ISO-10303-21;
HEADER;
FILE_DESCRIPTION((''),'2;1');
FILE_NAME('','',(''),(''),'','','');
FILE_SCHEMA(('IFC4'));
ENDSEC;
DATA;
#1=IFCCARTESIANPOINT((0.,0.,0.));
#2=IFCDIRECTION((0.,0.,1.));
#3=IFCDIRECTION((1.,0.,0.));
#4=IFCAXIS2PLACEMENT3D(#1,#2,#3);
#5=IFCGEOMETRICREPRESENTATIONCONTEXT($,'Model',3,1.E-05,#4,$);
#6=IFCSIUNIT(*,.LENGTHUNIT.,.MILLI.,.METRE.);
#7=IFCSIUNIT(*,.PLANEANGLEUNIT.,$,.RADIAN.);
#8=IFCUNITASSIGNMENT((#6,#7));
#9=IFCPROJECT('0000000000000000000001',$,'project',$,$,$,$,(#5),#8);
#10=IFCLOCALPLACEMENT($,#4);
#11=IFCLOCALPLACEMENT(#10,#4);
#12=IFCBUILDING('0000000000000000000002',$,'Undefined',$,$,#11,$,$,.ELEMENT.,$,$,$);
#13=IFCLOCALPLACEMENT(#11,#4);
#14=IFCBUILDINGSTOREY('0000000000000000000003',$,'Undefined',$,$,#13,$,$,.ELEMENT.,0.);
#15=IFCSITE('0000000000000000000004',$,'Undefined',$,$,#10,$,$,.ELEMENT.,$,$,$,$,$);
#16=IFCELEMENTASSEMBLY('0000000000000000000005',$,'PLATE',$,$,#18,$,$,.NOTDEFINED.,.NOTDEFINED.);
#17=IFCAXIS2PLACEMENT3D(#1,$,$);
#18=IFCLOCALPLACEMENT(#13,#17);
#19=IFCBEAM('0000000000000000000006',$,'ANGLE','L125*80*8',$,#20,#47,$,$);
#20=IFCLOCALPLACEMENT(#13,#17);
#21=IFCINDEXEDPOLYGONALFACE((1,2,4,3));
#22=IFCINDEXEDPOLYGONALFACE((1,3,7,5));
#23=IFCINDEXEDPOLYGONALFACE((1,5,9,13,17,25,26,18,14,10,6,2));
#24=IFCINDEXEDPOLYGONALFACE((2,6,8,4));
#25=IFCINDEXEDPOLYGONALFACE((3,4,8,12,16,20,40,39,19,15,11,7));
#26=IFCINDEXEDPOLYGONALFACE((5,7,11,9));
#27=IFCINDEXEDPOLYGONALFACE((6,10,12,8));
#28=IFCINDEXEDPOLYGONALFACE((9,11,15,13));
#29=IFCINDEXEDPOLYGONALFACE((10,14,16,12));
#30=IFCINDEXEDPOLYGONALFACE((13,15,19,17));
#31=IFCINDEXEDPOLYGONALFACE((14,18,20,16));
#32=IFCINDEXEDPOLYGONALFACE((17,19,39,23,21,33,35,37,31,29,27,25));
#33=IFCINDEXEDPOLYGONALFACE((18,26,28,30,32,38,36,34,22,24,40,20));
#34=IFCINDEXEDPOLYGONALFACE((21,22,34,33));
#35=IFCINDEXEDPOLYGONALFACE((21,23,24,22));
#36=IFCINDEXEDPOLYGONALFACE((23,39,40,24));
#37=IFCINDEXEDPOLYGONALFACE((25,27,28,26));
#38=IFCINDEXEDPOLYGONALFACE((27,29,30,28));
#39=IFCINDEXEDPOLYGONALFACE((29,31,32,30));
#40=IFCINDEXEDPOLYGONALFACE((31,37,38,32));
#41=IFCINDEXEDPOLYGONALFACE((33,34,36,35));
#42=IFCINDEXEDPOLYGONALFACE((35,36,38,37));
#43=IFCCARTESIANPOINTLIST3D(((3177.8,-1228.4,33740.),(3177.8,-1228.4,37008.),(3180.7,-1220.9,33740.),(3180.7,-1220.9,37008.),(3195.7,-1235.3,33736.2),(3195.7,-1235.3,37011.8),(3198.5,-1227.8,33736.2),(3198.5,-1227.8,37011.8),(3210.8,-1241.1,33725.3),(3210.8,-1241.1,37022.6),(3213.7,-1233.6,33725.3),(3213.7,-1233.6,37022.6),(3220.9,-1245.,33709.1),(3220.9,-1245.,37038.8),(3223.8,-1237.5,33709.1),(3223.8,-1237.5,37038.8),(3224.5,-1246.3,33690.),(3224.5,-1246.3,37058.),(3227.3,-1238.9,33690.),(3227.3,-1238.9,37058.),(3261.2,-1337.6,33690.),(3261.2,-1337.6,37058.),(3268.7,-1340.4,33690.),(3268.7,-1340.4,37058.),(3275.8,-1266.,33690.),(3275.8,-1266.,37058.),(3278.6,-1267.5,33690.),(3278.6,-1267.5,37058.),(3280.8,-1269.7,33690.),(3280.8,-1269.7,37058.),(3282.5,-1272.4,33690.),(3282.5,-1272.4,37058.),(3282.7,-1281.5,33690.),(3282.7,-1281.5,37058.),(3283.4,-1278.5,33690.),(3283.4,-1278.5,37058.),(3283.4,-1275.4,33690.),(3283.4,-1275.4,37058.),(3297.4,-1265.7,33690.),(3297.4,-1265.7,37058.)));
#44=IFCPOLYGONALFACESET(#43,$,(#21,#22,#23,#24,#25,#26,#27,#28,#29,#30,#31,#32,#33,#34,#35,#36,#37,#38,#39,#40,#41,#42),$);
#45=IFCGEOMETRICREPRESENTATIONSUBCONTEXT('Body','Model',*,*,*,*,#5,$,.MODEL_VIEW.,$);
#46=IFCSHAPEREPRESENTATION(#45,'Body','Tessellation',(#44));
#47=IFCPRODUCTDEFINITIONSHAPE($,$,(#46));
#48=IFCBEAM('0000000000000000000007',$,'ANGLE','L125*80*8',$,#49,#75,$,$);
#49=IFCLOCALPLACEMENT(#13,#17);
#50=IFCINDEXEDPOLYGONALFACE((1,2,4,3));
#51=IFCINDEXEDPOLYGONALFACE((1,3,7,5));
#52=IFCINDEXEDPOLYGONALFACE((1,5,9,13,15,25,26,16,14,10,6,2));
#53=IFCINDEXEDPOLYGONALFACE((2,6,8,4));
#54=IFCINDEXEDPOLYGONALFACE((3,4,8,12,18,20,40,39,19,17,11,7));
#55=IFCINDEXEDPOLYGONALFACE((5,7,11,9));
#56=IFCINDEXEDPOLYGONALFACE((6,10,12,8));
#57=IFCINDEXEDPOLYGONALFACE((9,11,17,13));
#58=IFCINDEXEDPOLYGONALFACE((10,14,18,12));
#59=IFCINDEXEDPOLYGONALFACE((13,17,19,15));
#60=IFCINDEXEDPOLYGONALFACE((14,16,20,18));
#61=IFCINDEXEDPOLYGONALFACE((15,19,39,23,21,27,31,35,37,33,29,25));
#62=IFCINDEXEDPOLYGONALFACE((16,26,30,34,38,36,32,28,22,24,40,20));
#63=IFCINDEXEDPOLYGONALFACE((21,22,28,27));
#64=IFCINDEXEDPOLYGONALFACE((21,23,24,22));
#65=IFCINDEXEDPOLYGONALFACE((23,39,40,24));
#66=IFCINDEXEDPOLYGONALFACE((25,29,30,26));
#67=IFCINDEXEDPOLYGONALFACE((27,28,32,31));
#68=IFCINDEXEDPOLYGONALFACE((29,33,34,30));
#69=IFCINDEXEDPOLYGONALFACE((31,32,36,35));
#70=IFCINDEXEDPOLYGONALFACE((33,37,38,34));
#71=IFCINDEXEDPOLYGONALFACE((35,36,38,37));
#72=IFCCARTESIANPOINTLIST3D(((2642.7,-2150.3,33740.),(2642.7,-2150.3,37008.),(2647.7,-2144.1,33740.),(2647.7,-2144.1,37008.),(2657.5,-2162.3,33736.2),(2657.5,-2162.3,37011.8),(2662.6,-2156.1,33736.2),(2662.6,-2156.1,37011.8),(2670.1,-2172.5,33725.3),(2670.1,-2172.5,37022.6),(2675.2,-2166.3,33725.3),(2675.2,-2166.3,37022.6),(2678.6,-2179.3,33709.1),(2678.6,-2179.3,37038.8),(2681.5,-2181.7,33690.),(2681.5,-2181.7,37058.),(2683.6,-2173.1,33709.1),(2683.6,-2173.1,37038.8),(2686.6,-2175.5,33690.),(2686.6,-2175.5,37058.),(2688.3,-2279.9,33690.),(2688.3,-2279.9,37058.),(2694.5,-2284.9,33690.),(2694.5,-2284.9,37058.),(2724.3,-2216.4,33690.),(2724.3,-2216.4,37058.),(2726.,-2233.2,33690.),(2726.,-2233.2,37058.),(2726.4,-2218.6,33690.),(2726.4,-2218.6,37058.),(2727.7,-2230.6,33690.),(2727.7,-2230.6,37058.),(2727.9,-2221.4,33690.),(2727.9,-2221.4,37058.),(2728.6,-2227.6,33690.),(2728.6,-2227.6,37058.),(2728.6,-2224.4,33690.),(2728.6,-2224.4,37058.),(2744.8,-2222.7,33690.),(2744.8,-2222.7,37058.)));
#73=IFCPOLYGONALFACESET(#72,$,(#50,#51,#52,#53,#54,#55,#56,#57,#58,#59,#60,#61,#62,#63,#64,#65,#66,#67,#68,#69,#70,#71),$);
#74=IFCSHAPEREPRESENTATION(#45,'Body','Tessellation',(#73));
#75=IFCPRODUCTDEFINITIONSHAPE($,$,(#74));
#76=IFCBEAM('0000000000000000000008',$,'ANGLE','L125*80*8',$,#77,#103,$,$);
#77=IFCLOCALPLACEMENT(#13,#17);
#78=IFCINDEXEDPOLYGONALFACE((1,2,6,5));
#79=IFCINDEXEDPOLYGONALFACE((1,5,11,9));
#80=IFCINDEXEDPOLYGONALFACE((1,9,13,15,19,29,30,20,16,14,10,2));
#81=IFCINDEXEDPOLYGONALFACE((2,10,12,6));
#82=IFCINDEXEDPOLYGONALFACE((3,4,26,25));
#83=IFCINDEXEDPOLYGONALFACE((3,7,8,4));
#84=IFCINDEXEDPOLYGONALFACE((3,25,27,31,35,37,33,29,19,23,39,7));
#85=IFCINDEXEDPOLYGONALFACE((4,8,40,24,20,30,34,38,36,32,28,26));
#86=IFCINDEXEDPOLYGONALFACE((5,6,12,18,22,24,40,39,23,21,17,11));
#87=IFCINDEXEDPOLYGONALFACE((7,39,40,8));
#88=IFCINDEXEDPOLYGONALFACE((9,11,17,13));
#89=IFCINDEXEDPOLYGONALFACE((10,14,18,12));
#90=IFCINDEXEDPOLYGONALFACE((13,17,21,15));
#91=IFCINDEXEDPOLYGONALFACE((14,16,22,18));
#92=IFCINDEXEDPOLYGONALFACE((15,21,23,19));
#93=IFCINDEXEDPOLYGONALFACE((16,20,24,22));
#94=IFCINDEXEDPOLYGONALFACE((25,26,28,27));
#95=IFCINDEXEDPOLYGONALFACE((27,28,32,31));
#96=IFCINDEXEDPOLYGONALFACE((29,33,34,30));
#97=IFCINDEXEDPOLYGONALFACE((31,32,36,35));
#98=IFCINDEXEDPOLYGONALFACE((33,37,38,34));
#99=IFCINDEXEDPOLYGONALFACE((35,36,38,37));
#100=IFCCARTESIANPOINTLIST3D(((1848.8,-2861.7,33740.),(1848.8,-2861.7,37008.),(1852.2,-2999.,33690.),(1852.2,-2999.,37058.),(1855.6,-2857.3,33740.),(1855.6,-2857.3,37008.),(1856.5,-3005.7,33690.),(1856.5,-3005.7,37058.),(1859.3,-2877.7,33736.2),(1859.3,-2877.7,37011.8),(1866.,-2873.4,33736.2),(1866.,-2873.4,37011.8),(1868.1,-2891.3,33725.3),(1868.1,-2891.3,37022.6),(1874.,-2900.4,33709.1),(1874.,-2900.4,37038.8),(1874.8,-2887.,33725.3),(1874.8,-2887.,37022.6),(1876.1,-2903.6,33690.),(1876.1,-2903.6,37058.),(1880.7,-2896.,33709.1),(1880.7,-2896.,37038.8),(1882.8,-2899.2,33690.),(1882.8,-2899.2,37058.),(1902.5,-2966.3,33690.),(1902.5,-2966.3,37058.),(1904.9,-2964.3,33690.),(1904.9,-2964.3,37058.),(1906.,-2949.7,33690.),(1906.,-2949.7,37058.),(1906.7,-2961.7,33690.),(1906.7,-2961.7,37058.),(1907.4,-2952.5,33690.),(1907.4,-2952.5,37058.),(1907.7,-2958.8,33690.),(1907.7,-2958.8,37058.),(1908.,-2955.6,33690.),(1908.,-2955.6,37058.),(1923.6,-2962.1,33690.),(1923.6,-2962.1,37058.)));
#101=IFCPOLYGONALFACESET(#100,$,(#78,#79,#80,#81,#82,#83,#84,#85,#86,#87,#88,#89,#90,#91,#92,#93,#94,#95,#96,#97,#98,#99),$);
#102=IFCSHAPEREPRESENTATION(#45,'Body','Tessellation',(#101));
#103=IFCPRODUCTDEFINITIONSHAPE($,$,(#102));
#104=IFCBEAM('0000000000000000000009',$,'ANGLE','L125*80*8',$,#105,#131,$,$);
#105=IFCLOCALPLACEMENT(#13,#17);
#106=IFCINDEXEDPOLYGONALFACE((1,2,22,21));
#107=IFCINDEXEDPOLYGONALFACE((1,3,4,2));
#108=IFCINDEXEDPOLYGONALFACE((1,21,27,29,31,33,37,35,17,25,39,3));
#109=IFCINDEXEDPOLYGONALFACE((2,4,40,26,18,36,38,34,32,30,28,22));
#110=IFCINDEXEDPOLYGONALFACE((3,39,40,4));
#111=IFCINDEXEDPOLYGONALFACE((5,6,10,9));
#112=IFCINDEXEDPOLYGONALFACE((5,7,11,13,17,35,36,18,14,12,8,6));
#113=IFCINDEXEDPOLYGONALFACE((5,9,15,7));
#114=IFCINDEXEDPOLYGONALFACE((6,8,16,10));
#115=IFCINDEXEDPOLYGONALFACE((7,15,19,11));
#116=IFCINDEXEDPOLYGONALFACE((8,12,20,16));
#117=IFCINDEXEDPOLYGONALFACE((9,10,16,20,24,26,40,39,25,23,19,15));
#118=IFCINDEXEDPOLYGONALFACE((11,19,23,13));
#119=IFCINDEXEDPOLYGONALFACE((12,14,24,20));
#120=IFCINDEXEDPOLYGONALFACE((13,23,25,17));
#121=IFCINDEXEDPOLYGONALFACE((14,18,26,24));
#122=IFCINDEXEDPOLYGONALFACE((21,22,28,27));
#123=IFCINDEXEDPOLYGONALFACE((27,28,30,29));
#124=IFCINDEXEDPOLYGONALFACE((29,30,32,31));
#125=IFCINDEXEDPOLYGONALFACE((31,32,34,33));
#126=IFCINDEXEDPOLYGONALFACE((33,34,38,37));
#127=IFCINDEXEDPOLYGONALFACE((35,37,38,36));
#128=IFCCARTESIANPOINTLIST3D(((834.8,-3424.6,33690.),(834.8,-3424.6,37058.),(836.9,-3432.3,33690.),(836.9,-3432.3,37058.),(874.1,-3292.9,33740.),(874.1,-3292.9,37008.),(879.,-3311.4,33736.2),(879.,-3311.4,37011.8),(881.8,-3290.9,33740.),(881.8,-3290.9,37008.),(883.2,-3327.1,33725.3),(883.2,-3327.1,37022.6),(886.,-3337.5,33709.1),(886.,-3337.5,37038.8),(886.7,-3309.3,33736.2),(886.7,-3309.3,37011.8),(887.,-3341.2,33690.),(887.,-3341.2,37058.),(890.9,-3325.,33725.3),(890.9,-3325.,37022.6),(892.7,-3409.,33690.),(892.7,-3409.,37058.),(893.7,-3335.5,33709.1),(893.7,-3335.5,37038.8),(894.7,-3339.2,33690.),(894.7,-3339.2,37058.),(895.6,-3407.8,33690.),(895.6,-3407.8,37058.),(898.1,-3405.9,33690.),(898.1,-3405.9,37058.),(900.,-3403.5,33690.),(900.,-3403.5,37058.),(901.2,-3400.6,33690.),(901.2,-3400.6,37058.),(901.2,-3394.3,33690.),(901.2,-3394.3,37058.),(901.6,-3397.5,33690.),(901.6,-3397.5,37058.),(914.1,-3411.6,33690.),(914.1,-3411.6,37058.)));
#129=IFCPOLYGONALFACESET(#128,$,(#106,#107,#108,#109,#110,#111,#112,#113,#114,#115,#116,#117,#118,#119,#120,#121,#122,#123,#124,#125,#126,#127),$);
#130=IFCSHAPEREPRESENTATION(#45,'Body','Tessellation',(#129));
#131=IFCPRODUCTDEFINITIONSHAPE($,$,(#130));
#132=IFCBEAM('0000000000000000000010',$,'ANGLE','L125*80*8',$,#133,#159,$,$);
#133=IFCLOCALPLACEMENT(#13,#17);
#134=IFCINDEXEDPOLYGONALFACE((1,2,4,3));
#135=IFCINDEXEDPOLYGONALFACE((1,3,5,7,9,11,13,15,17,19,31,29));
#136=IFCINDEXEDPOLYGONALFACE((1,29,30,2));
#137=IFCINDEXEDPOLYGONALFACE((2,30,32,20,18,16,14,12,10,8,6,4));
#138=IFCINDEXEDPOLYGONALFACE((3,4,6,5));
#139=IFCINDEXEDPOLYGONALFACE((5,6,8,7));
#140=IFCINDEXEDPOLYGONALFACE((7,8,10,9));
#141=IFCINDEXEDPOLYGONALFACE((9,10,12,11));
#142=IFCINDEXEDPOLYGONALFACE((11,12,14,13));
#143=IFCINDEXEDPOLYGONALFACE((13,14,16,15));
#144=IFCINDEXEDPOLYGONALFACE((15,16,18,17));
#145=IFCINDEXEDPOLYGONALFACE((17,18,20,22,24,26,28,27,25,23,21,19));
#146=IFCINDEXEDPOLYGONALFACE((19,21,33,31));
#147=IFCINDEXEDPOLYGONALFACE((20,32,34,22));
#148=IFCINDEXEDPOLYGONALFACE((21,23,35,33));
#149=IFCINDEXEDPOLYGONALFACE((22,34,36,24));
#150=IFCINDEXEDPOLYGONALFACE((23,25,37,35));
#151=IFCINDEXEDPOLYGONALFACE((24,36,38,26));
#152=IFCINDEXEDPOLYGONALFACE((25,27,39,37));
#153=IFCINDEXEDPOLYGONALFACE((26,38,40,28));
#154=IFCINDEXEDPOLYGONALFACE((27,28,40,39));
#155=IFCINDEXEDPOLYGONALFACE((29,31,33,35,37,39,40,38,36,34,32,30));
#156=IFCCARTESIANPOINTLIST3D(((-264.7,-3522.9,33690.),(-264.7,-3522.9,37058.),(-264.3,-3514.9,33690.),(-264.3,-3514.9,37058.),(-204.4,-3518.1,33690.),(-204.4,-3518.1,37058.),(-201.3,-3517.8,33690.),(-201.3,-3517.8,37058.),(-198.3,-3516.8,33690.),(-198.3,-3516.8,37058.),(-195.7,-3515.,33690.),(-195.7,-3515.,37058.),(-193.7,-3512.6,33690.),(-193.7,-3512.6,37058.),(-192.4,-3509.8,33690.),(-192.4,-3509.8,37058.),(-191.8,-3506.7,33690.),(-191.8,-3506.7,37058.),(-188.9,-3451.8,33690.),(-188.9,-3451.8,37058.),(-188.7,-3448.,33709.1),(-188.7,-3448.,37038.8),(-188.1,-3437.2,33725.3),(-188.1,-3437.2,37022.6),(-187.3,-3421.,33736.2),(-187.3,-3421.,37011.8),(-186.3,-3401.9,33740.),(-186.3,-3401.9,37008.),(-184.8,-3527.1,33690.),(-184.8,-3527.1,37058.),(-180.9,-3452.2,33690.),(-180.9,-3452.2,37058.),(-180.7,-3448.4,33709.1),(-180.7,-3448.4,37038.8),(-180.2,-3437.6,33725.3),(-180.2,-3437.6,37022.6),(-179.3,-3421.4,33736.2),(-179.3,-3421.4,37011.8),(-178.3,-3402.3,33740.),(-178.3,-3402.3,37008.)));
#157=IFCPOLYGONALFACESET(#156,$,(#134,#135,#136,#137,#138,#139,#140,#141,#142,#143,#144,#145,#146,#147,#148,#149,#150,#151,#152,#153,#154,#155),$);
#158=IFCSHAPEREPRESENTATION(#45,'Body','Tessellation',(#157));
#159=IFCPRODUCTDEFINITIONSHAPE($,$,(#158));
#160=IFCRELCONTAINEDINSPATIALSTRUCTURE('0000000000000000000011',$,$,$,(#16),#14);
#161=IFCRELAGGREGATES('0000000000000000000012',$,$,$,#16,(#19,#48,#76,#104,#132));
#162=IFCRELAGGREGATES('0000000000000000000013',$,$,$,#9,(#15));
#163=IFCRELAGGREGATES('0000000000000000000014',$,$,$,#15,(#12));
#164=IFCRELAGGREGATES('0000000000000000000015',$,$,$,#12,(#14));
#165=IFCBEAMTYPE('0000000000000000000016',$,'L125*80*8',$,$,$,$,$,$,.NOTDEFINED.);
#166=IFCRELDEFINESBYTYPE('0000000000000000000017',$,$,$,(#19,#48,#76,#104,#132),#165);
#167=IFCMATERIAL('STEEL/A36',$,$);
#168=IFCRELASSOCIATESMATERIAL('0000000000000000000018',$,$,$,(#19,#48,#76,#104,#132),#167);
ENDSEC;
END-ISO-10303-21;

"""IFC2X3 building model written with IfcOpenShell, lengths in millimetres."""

from ifc_helpers import new_model, si_unit, frame, origin_with_axes, origin_2d_with_axis, place, context, subcontext, project, spatial, polyline, l_section, outline, extrude, boolean, material, type_object, element, aggregate, save


model = new_model("IFC2X3")

# Units and contexts
model_context = context("Model", 3, precision=1e-05, world=origin_with_axes())
body_context = subcontext(model_context, "Body", "Model", "MODEL_VIEW")
ifc_project = project(units=[si_unit("LENGTHUNIT", "METRE", prefix="MILLI"), si_unit("PLANEANGLEUNIT", "RADIAN")], contexts=[model_context])

# Site, building, storey
site_placement = place(None, origin_with_axes())
site = spatial("IfcSite", under=ifc_project, at=site_placement, Name="Undefined", CompositionType="ELEMENT")
building_placement = place(site_placement, origin_with_axes())
building = spatial("IfcBuilding", under=site, at=building_placement, Name="Undefined", CompositionType="ELEMENT")
storey_placement = place(building_placement, origin_with_axes())
storey = spatial("IfcBuildingStorey", under=building, at=storey_placement, Name="Undefined", CompositionType="ELEMENT", Elevation=0.0)

# Element assembly, beams
assembly_1_placement = place(storey_placement, origin_with_axes())
assembly_1 = element("IfcElementAssembly", 1, at=assembly_1_placement, inside=storey, Name="PLATE", AssemblyPlace="NOTDEFINED", PredefinedType="NOTDEFINED")
ifc_material_1 = material(Name="STEEL/A36")
beam_type = type_object("IfcBeamType", Name="L125*80*8", PredefinedType="NOTDEFINED")
beam_1_placement = place(assembly_1_placement, frame((3224.7, -1280.7, 33690.0), z_axis=(-0.93358, 0.358368, 0.0), x_axis=(0.0, 0.0, 1.0)))
beam_1 = element("IfcBeam", 2, at=beam_1_placement, type_object=beam_type, material=ifc_material_1, Name="ANGLE", Description="L125*80*8", context=body_context, shape_type="CSG", body=[
    boolean("DIFFERENCE", boolean("DIFFERENCE", extrude(l_section(Depth=125.0, Width=80.0, Thickness=8.0, FilletRadius=12.0, at=origin_2d_with_axis()), frame((3368.0, 0.0, 0.0), z_axis=(-1.0, 0.0, 0.0), x_axis=(0.0, -1.0, 0.0)), (0.0, 0.0, 1.0), 3368.0), extrude(outline(polyline([(0.0, 0.0), (50.0, 0.0), (50.0, 0.0), (46.2, 19.1), (35.4, 35.4), (19.1, 46.2), (0.0, 50.0), (0.0, 50.0), (0.0, 0.0)])), frame((0.0, -38.0, 62.5), z_axis=(0.0, 1.0, 0.0), x_axis=(1.0, 0.0, 0.0)), (0.0, 0.0, 1.0), 81.0)), extrude(outline(polyline([(0.0, 0.0), (50.0, 0.0), (50.0, 0.0), (46.2, 19.1), (35.4, 35.4), (19.1, 46.2), (0.0, 50.0), (0.0, 50.0), (0.0, 0.0)])), frame((3368.0, -38.0, 62.5), z_axis=(0.0, 1.0, 0.0), x_axis=(-0.000152, -0.000001, -1.0)), (0.0, 0.0, 1.0), 81.0)),
])
beam_2_placement = place(assembly_1_placement, frame((2671.1, -2214.5, 33690.0), z_axis=(-0.777146, 0.62932, 0.0), x_axis=(0.0, 0.0, 1.0)))
beam_2 = element("IfcBeam", 3, at=beam_2_placement, type_object=beam_type, material=ifc_material_1, Name="ANGLE", Description="L125*80*8", context=body_context, shape_type="CSG", body=[
    boolean("DIFFERENCE", boolean("DIFFERENCE", extrude(l_section(Depth=125.0, Width=80.0, Thickness=8.0, FilletRadius=12.0, at=origin_2d_with_axis()), frame((3368.0, 0.0, 0.0), z_axis=(-1.0, 0.0, 0.0), x_axis=(0.0, -1.0, 0.0)), (0.0, 0.0, 1.0), 3368.0), extrude(outline(polyline([(0.0, 0.0), (50.0, 0.0), (50.0, 0.0), (46.2, 19.1), (35.4, 35.4), (19.1, 46.2), (0.0, 50.0), (0.0, 50.0), (0.0, 0.0)])), frame((0.0, -38.0, 62.5), z_axis=(0.0, 1.0, 0.0), x_axis=(1.0, 0.0, 0.0)), (0.0, 0.0, 1.0), 81.0)), extrude(outline(polyline([(0.0, 0.0), (50.0, 0.0), (50.0, 0.0), (46.2, 19.1), (35.4, 35.4), (19.1, 46.2), (0.0, 50.0), (0.0, 50.0), (0.0, 0.0)])), frame((3368.0, -38.0, 62.5), z_axis=(0.0, 1.0, 0.0), x_axis=(-0.000152, -0.000001, -1.0)), (0.0, 0.0, 1.0), 81.0)),
])
beam_3_placement = place(assembly_1_placement, frame((1856.0, -2931.5, 33690.0), z_axis=(-0.544639, 0.838671, 0.0), x_axis=(0.0, 0.0, 1.0)))
beam_3 = element("IfcBeam", 4, at=beam_3_placement, type_object=beam_type, material=ifc_material_1, Name="ANGLE", Description="L125*80*8", context=body_context, shape_type="CSG", body=[
    boolean("DIFFERENCE", boolean("DIFFERENCE", extrude(l_section(Depth=125.0, Width=80.0, Thickness=8.0, FilletRadius=12.0, at=origin_2d_with_axis()), frame((3368.0, 0.0, 0.0), z_axis=(-1.0, 0.0, 0.0), x_axis=(0.0, -1.0, 0.0)), (0.0, 0.0, 1.0), 3368.0), extrude(outline(polyline([(0.0, 0.0), (50.0, 0.0), (50.0, 0.0), (46.2, 19.1), (35.4, 35.4), (19.1, 46.2), (0.0, 50.0), (0.0, 50.0), (0.0, 0.0)])), frame((0.0, -38.0, 62.5), z_axis=(0.0, 1.0, 0.0), x_axis=(1.0, 0.0, 0.0)), (0.0, 0.0, 1.0), 81.0)), extrude(outline(polyline([(0.0, 0.0), (50.0, 0.0), (50.0, 0.0), (46.2, 19.1), (35.4, 35.4), (19.1, 46.2), (0.0, 50.0), (0.0, 50.0), (0.0, 0.0)])), frame((3368.0, -38.0, 62.5), z_axis=(0.0, 1.0, 0.0), x_axis=(-0.000152, -0.000001, -1.0)), (0.0, 0.0, 1.0), 81.0)),
])
beam_4_placement = place(assembly_1_placement, frame((859.3, -3361.6, 33690.0), z_axis=(-0.258819, 0.965926, 0.0), x_axis=(0.0, 0.0, 1.0)))
beam_4 = element("IfcBeam", 5, at=beam_4_placement, type_object=beam_type, material=ifc_material_1, Name="ANGLE", Description="L125*80*8", context=body_context, shape_type="CSG", body=[
    boolean("DIFFERENCE", boolean("DIFFERENCE", extrude(l_section(Depth=125.0, Width=80.0, Thickness=8.0, FilletRadius=12.0, at=origin_2d_with_axis()), frame((3368.0, 0.0, 0.0), z_axis=(-1.0, 0.0, 0.0), x_axis=(0.0, -1.0, 0.0)), (0.0, 0.0, 1.0), 3368.0), extrude(outline(polyline([(0.0, 0.0), (50.0, 0.0), (50.0, 0.0), (46.2, 19.1), (35.4, 35.4), (19.1, 46.2), (0.0, 50.0), (0.0, 50.0), (0.0, 0.0)])), frame((0.0, -38.0, 62.5), z_axis=(0.0, 1.0, 0.0), x_axis=(1.0, 0.0, 0.0)), (0.0, 0.0, 1.0), 81.0)), extrude(outline(polyline([(0.0, 0.0), (50.0, 0.0), (50.0, 0.0), (46.2, 19.1), (35.4, 35.4), (19.1, 46.2), (0.0, 50.0), (0.0, 50.0), (0.0, 0.0)])), frame((3368.0, -38.0, 62.5), z_axis=(0.0, 1.0, 0.0), x_axis=(-0.000152, -0.000001, -1.0)), (0.0, 0.0, 1.0), 81.0)),
])
beam_5_placement = place(assembly_1_placement, frame((-221.5, -3462.6, 33690.0), z_axis=(0.052336, 0.99863, 0.0), x_axis=(0.0, 0.0, 1.0)))
beam_5 = element("IfcBeam", 6, at=beam_5_placement, type_object=beam_type, material=ifc_material_1, Name="ANGLE", Description="L125*80*8", context=body_context, shape_type="CSG", body=[
    boolean("DIFFERENCE", boolean("DIFFERENCE", extrude(l_section(Depth=125.0, Width=80.0, Thickness=8.0, FilletRadius=12.0, at=origin_2d_with_axis()), frame((3368.0, 0.0, 0.0), z_axis=(-1.0, 0.0, 0.0), x_axis=(0.0, -1.0, 0.0)), (0.0, 0.0, 1.0), 3368.0), extrude(outline(polyline([(0.0, 0.0), (50.0, 0.0), (50.0, 0.0), (46.2, 19.1), (35.4, 35.4), (19.1, 46.2), (0.0, 50.0), (0.0, 50.0), (0.0, 0.0)])), frame((0.0, -38.0, 62.5), z_axis=(0.0, 1.0, 0.0), x_axis=(1.0, 0.0, 0.0)), (0.0, 0.0, 1.0), 81.0)), extrude(outline(polyline([(0.0, 0.0), (50.0, 0.0), (50.0, 0.0), (46.2, 19.1), (35.4, 35.4), (19.1, 46.2), (0.0, 50.0), (0.0, 50.0), (0.0, 0.0)])), frame((3368.0, -38.0, 62.5), z_axis=(0.0, 1.0, 0.0), x_axis=(-0.000152, -0.000001, -1.0)), (0.0, 0.0, 1.0), 81.0)),
])
aggregate(assembly_1, [beam_1, beam_2, beam_3, beam_4, beam_5])

save(model, "model.ifc")
